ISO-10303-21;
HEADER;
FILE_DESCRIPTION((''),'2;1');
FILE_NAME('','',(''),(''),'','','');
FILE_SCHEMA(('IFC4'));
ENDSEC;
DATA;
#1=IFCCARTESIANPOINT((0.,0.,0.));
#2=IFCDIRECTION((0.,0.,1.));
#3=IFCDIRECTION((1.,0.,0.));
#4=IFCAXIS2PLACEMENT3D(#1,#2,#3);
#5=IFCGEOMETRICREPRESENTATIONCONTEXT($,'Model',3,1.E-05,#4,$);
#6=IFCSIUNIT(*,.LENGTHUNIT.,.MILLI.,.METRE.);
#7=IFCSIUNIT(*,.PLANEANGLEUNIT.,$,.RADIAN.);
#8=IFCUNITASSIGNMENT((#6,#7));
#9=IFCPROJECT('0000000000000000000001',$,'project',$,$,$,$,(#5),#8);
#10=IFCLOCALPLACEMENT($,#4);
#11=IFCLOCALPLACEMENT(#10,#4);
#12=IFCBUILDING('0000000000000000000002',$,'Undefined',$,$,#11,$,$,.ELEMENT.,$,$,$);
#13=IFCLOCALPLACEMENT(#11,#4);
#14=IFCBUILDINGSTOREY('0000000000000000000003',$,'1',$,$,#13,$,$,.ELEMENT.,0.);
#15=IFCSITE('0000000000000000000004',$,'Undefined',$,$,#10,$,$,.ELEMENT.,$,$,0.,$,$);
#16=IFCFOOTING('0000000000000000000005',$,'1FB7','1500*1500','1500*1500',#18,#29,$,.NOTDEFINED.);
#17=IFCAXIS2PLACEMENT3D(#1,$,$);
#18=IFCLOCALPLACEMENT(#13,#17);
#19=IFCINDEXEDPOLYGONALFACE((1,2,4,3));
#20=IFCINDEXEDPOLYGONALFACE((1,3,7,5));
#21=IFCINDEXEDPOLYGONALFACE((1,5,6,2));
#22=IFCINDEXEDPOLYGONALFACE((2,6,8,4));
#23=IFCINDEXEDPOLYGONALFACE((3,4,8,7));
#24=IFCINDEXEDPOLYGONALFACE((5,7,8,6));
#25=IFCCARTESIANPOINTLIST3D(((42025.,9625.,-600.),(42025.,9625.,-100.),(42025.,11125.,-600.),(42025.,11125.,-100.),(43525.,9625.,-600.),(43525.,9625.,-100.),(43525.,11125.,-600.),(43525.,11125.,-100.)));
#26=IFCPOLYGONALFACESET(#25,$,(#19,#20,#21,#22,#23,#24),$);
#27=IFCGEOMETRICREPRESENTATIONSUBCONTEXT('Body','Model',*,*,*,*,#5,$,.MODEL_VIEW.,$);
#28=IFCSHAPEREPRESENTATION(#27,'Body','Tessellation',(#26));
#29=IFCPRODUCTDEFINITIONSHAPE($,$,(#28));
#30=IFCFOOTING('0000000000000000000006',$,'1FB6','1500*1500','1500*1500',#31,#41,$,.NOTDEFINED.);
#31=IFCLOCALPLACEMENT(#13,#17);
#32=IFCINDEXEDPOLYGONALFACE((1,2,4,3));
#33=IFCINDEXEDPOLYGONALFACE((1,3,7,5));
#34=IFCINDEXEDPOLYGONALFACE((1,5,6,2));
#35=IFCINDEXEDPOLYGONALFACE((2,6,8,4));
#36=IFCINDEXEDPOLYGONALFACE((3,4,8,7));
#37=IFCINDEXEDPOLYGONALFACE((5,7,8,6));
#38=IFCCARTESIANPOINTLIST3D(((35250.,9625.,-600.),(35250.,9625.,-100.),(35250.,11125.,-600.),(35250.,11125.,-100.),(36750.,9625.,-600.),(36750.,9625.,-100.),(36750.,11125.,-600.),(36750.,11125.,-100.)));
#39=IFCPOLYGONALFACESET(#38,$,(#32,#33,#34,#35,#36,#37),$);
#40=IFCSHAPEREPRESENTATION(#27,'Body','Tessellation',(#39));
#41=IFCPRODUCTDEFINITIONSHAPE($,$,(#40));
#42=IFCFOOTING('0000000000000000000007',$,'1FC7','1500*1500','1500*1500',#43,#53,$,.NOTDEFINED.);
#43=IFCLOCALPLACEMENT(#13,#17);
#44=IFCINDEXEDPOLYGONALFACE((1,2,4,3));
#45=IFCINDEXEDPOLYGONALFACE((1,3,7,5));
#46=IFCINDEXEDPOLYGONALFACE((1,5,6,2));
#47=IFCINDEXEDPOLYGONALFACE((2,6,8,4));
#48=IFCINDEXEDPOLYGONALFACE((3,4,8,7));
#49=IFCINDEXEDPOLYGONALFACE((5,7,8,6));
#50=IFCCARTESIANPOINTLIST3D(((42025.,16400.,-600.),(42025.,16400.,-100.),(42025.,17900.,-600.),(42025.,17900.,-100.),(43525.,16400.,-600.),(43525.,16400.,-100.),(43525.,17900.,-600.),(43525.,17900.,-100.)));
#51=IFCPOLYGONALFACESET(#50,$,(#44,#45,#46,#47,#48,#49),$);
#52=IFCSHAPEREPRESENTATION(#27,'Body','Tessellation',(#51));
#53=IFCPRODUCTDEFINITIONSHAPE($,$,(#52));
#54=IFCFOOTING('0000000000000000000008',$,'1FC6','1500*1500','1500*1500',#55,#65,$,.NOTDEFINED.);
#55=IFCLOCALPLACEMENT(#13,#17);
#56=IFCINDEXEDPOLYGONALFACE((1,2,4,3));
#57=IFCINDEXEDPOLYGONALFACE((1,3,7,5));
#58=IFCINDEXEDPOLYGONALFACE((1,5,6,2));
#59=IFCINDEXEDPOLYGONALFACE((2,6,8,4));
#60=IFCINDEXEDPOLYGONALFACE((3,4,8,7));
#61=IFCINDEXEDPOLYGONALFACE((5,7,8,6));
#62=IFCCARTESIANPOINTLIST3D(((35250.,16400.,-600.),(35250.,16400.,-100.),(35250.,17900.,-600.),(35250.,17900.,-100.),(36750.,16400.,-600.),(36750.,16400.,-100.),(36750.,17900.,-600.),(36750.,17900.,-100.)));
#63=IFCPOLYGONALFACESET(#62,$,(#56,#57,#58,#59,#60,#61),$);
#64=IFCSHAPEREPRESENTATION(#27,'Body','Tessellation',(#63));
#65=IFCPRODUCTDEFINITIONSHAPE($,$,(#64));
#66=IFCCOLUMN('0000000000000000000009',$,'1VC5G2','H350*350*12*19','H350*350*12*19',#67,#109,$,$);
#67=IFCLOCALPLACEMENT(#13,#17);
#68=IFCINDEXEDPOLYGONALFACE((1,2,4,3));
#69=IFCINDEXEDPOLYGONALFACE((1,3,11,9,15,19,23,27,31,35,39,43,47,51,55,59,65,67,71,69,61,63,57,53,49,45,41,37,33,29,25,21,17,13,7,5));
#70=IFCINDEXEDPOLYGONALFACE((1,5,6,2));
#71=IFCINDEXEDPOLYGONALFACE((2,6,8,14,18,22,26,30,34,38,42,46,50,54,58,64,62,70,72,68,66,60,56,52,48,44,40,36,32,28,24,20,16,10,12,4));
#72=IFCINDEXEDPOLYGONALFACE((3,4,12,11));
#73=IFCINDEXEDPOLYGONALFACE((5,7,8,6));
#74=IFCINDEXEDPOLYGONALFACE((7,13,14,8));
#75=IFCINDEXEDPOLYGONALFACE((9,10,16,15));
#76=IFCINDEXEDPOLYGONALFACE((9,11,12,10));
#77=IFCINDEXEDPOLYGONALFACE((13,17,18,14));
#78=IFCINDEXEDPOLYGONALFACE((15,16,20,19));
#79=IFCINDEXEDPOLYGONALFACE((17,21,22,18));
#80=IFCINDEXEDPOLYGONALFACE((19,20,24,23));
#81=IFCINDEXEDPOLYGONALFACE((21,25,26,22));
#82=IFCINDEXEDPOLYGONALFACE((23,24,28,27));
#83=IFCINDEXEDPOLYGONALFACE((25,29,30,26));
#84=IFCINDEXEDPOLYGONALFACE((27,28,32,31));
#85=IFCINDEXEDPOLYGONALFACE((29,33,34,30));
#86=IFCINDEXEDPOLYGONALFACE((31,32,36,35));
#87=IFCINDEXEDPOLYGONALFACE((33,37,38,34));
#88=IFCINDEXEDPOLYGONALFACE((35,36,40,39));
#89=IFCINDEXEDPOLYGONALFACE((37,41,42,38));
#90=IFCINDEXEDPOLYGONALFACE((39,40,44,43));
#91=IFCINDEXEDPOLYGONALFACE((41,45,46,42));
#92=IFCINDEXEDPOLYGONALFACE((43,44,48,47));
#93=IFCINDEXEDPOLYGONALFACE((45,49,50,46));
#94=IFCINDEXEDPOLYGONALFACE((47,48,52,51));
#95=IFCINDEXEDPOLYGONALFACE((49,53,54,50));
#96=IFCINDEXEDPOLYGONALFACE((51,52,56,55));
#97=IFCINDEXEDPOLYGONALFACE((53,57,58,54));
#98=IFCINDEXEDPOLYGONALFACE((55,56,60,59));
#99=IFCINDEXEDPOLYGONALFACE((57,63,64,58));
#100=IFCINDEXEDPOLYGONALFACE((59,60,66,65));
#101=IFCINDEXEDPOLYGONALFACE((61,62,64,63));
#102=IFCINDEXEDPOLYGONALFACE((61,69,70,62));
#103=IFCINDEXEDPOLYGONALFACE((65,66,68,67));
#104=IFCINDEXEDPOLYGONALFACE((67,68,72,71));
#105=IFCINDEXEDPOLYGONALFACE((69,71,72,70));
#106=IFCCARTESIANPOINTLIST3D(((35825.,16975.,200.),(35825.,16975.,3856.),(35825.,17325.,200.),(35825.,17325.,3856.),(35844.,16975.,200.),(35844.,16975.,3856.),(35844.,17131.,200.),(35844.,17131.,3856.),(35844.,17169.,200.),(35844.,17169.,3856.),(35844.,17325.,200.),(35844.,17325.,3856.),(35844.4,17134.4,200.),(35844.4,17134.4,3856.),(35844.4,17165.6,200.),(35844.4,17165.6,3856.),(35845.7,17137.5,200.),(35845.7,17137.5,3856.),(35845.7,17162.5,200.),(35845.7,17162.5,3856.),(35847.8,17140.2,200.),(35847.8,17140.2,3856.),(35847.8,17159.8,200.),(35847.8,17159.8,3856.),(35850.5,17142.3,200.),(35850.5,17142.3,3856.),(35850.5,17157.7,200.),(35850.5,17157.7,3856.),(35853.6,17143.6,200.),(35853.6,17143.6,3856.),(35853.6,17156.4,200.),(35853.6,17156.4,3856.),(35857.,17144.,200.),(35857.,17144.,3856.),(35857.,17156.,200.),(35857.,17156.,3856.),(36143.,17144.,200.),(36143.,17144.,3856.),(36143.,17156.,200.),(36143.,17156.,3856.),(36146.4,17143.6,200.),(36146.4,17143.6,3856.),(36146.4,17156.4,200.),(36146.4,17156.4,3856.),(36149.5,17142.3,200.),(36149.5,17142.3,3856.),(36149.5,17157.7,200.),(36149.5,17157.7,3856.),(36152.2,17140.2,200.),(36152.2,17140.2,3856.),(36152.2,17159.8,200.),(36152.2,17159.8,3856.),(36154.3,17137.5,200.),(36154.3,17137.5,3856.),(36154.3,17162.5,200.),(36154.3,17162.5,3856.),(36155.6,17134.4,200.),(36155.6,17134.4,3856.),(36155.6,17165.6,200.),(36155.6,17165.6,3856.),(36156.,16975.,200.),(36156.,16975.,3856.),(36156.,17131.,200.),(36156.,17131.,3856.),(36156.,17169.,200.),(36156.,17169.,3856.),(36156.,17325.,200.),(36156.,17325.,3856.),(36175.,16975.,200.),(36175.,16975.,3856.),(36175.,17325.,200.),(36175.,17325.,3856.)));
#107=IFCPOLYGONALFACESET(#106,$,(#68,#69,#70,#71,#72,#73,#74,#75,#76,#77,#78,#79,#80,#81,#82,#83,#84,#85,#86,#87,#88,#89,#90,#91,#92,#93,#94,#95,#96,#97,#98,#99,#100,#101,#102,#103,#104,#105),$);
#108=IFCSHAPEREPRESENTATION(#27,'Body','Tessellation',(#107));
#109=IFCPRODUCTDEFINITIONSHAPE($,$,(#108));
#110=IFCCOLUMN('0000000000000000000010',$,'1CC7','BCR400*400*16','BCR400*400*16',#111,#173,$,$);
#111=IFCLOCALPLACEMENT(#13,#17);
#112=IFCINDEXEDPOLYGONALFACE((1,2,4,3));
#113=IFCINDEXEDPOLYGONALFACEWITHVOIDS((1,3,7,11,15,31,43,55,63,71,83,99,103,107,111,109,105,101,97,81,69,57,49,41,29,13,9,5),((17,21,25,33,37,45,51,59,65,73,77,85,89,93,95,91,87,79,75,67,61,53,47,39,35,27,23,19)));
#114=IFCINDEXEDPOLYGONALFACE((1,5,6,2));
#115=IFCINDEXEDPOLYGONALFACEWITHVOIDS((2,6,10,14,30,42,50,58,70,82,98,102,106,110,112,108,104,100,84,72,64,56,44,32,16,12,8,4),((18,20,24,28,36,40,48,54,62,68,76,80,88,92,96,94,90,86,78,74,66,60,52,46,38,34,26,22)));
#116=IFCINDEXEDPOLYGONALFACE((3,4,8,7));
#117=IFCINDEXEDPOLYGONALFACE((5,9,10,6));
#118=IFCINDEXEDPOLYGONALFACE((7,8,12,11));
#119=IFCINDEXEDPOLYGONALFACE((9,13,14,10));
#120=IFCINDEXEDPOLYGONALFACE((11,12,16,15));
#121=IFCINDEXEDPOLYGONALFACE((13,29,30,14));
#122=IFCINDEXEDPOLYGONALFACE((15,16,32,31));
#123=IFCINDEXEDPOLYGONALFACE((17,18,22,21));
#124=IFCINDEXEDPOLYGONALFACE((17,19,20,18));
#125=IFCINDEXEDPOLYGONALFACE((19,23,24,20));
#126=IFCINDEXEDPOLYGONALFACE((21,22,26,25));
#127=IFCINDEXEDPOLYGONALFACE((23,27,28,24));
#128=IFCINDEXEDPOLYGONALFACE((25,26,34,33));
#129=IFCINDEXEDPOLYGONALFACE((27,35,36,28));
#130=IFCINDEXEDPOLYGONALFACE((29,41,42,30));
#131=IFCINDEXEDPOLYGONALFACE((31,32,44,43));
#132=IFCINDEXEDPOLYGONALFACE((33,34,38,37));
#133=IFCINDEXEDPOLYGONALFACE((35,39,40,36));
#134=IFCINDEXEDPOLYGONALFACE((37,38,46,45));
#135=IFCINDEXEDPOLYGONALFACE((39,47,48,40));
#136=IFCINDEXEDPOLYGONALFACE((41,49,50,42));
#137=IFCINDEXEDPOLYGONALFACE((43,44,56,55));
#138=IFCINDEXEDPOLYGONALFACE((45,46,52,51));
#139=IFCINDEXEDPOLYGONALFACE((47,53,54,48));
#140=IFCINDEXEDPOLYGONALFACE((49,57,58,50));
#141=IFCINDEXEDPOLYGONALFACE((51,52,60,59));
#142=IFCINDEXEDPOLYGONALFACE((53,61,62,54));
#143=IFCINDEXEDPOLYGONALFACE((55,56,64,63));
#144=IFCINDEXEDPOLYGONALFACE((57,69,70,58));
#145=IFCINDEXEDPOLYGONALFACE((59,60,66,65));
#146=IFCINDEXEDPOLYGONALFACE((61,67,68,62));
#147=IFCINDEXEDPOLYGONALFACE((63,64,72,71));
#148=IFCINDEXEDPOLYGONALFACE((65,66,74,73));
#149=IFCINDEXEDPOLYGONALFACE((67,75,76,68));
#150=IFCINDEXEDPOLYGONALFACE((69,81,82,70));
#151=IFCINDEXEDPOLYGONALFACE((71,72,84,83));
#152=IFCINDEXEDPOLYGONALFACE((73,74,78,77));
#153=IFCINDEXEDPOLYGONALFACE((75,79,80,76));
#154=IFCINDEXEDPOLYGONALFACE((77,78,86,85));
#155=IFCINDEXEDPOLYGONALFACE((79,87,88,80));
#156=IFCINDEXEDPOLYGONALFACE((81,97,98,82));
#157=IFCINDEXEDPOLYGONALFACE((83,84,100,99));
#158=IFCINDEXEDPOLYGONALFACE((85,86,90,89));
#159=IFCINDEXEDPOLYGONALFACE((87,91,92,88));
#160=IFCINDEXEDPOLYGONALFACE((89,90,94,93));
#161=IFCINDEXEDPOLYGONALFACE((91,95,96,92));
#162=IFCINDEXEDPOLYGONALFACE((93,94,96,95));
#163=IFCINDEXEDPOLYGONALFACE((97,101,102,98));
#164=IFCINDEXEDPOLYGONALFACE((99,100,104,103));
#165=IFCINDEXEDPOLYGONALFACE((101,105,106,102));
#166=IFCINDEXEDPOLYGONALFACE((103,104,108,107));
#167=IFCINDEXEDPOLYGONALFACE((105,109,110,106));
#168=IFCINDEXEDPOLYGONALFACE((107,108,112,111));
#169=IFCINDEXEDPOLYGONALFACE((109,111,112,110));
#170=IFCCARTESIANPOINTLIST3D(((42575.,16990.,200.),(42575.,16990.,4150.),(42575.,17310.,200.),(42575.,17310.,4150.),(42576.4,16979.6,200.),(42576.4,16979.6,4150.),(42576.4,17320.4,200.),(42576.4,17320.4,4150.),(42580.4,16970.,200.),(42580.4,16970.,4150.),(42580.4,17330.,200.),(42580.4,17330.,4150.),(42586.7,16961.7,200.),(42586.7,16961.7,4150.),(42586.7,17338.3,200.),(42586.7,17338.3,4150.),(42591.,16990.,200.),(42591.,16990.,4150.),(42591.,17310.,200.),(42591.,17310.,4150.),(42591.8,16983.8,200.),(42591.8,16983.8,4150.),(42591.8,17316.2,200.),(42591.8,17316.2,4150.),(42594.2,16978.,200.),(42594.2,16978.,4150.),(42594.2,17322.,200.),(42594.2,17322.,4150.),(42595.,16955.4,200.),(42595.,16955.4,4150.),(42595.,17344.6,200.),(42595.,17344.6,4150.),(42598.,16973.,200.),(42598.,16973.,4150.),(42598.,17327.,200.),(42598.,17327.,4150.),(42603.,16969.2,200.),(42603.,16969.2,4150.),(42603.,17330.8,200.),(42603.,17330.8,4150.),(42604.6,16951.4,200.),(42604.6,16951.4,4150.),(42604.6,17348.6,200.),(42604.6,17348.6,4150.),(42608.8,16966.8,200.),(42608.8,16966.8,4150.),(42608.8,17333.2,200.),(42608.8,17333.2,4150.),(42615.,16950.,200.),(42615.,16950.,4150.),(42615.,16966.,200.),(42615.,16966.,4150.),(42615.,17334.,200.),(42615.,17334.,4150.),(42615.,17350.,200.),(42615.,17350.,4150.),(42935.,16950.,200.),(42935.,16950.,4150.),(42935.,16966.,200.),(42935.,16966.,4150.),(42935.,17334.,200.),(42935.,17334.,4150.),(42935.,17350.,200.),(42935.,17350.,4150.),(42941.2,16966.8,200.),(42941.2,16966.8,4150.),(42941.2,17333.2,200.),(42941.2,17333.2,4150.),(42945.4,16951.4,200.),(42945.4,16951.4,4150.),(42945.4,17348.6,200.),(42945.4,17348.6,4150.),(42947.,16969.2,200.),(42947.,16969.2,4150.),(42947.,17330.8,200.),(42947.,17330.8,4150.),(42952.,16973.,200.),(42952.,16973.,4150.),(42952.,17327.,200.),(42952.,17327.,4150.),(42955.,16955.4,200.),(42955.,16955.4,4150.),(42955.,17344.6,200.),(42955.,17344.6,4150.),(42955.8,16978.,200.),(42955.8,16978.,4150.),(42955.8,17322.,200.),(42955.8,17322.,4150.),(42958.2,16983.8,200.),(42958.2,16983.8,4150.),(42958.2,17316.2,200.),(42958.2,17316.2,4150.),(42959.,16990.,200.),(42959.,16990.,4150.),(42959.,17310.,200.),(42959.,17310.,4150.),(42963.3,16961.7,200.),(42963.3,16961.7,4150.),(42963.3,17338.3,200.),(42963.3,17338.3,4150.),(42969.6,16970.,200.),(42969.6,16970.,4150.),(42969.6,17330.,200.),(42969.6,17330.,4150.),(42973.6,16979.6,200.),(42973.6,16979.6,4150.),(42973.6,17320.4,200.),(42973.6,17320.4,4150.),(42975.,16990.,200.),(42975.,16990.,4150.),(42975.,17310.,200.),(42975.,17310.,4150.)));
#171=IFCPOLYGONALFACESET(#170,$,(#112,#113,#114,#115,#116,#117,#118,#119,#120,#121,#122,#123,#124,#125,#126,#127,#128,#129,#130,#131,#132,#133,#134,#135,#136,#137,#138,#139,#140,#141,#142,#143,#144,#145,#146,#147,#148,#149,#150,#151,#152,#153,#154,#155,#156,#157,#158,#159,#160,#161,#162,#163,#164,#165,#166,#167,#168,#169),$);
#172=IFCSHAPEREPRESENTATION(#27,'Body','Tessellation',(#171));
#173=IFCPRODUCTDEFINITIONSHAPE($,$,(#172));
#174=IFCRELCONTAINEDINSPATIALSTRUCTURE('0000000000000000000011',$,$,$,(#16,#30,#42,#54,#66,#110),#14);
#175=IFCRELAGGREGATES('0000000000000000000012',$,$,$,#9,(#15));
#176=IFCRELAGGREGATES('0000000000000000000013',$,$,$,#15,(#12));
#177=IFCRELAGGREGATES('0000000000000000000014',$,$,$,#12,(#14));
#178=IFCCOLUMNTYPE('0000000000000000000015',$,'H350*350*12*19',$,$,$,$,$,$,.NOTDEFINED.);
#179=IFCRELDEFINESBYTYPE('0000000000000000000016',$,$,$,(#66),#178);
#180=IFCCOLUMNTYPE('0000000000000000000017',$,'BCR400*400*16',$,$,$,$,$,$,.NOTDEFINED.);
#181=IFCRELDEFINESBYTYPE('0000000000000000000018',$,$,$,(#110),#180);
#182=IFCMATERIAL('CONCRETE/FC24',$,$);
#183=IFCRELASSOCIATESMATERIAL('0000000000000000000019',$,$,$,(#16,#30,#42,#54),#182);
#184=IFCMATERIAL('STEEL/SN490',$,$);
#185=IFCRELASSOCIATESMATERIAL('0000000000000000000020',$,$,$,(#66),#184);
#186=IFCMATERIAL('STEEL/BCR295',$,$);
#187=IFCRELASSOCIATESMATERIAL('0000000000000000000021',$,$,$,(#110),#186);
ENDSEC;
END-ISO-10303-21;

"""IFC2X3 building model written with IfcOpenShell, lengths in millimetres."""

from ifc_helpers import new_model, si_unit, frame, origin_with_axes, origin_2d_with_axis, place, context, subcontext, project, spatial, rectangle, hollow_rectangle, i_section, extrude, material, type_object, element, save


model = new_model("IFC2X3")

# Units and contexts
model_context = context("Model", 3, precision=1e-05, world=origin_with_axes())
body_context = subcontext(model_context, "Body", "Model", "MODEL_VIEW")
ifc_project = project(units=[si_unit("LENGTHUNIT", "METRE", prefix="MILLI"), si_unit("PLANEANGLEUNIT", "RADIAN")], contexts=[model_context])

# Site, building, storey
site_placement = place(None, origin_with_axes())
site = spatial("IfcSite", under=ifc_project, at=site_placement, Name="Undefined", CompositionType="ELEMENT", RefElevation=0.0)
building_placement = place(site_placement, origin_with_axes())
building = spatial("IfcBuilding", under=site, at=building_placement, Name="Undefined", CompositionType="ELEMENT")
storey_placement = place(building_placement, origin_with_axes())
storey = spatial("IfcBuildingStorey", under=building, at=storey_placement, Name="1", CompositionType="ELEMENT", Elevation=0.0)

# Footings
ifc_material_1 = material(Name="CONCRETE/FC24")
for number, where, z_axis, x_axis, name in (
    (1, (42775.0, 10375.0, -600.0), (0.0, 1.0, 0.0), (0.0, 0.0, 1.0), "1FB7"),
    (2, (36000.0, 10375.0, -600.0), (0.0, 1.0, 0.0), (0.0, 0.0, 1.0), "1FB6"),
    (3, (42775.0, 17150.0, -600.0), (0.0, 1.0, 0.0), (0.0, 0.0, 1.0), "1FC7"),
    (4, (36000.0, 17150.0, -600.0), (0.0, 1.0, 0.0), (0.0, 0.0, 1.0), "1FC6"),
):
    element("IfcFooting", number, at=place(storey_placement, frame(where, z_axis=z_axis, x_axis=x_axis)), inside=storey, material=ifc_material_1, Name=name, Description="1500*1500", ObjectType="1500*1500", PredefinedType="NOTDEFINED", context=body_context, shape_type="SweptSolid", body=[
        extrude(rectangle(XDim=1500.0, YDim=1500.0, at=origin_2d_with_axis()), frame((500.0, 0.0, 0.0), z_axis=(-1.0, 0.0, 0.0), x_axis=(0.0, -1.0, 0.0)), (0.0, 0.0, 1.0), 500.0),
    ])

# Columns
ifc_material_2 = material(Name="STEEL/SN490")
column_type_1 = type_object("IfcColumnType", Name="H350*350*12*19", PredefinedType="NOTDEFINED")
column_placement = place(storey_placement, frame((36000.0, 17150.0, 200.0), z_axis=(0.0, 0.0, 1.0), x_axis=(-1.0, 0.0, 0.0)))
element("IfcColumn", 5, at=column_placement, inside=storey, type_object=column_type_1, material=ifc_material_2, Name="1VC5G2", Description="H350*350*12*19", ObjectType="H350*350*12*19", context=body_context, shape_type="SweptSolid", body=[
    extrude(i_section(OverallWidth=350.0, OverallDepth=350.0, WebThickness=12.0, FlangeThickness=19.0, FilletRadius=13.0, at=origin_2d_with_axis()), frame((0.0, 0.0, 3656.0), z_axis=(0.0, 0.0, -1.0), x_axis=(0.0, 1.0, 0.0)), (0.0, 0.0, 1.0), 3656.0),
])
ifc_material_3 = material(Name="STEEL/BCR295")
column_type_2 = type_object("IfcColumnType", Name="BCR400*400*16", PredefinedType="NOTDEFINED")
for number, where, z_axis, x_axis, name in (
    (6, (42775.0, 17150.0, 200.0), (0.0, 0.0, 1.0), (0.0, 1.0, 0.0), "1CC7"),
):
    element("IfcColumn", number, at=place(storey_placement, frame(where, z_axis=z_axis, x_axis=x_axis)), inside=storey, type_object=column_type_2, material=ifc_material_3, Name=name, Description="BCR400*400*16", ObjectType="BCR400*400*16", context=body_context, shape_type="SweptSolid", body=[
        extrude(hollow_rectangle(XDim=400.0, YDim=400.0, WallThickness=16.0, InnerFilletRadius=24.0, OuterFilletRadius=40.0, at=origin_2d_with_axis()), frame((0.0, 0.0, 3950.0), z_axis=(0.0, 0.0, -1.0), x_axis=(0.0, 1.0, 0.0)), (0.0, 0.0, 1.0), 3950.0),
    ])

save(model, "model.ifc")
